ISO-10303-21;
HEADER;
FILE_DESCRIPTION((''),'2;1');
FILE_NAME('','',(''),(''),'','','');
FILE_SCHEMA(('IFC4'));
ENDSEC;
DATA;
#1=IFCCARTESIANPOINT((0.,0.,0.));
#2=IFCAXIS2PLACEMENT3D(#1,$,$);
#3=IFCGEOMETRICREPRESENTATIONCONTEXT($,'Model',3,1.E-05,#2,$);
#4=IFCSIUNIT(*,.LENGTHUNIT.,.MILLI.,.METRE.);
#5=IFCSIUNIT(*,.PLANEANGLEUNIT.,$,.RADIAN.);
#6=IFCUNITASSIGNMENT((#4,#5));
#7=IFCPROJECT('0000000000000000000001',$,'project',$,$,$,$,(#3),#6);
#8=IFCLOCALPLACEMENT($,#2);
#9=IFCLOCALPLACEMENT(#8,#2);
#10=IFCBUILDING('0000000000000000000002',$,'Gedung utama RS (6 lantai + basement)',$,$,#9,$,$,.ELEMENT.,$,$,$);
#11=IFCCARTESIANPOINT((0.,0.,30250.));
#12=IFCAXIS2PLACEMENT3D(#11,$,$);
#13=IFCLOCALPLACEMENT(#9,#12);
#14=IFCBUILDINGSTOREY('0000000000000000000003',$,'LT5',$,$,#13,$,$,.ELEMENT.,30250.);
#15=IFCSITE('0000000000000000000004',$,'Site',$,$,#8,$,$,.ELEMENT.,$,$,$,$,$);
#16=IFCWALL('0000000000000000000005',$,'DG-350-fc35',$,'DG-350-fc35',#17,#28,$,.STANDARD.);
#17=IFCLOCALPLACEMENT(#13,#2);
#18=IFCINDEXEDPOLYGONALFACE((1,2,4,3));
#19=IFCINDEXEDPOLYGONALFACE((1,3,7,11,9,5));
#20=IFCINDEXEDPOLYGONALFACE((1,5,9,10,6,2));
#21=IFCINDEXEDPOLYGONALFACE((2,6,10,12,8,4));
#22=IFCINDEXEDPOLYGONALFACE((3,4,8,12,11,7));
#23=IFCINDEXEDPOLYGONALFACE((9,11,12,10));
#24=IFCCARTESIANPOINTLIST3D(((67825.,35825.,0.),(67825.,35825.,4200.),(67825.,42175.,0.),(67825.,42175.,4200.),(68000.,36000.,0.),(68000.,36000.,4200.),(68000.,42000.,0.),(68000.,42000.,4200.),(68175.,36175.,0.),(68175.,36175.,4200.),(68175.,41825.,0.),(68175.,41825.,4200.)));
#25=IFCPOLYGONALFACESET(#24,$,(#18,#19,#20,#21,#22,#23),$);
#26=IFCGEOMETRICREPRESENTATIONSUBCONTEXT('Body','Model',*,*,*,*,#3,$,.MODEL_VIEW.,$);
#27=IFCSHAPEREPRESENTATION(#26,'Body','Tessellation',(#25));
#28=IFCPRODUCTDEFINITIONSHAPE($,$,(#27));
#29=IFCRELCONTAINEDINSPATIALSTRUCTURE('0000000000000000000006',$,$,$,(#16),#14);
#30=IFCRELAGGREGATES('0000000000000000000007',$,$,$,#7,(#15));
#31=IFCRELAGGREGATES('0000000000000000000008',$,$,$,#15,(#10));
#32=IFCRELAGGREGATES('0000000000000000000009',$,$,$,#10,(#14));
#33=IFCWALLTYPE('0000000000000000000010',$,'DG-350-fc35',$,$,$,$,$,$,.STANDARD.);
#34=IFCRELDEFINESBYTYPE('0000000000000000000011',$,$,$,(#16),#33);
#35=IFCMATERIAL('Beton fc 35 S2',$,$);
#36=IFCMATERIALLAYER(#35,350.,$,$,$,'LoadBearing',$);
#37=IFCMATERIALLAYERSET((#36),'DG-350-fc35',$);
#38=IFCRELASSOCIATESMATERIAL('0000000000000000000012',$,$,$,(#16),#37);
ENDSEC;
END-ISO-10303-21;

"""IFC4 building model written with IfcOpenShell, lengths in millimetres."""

from ifc_helpers import new_model, si_unit, frame, origin, place, context, subcontext, project, spatial, polyline, outline, extrude, material, layer, layer_set, layer_usage, type_object, element, save


model = new_model("IFC4")

# Units and contexts
model_context = context("Model", 3, precision=1e-05, world=origin())
body_context = subcontext(model_context, "Body", "Model", "MODEL_VIEW")
ifc_project = project(units=[si_unit("LENGTHUNIT", "METRE", prefix="MILLI"), si_unit("PLANEANGLEUNIT", "RADIAN")], contexts=[model_context])

# Site, building, storey
site_placement = place(None, origin())
site = spatial("IfcSite", under=ifc_project, at=site_placement, Name="Site", CompositionType="ELEMENT")
building_placement = place(site_placement, origin())
building = spatial("IfcBuilding", under=site, at=building_placement, Name="Gedung utama RS (6 lantai + basement)", CompositionType="ELEMENT")
storey_placement = place(building_placement, frame((0.0, 0.0, 30250.0)))
storey = spatial("IfcBuildingStorey", under=building, at=storey_placement, Name="LT5", CompositionType="ELEMENT", Elevation=30250.0)

# Shared definitions
ifc_material_1 = material(Name="Beton fc 35 S2")
ifc_layer = layer(ifc_material_1, 350.0, Category="LoadBearing")
ifc_layer_set = layer_set([ifc_layer], Name="DG-350-fc35")
ifc_layer_usage = layer_usage(ifc_layer_set, "AXIS2", "NEGATIVE", 175.0)
wall_type = type_object("IfcWallType", Name="DG-350-fc35", PredefinedType="STANDARD")

# Wall
wall_1_placement = place(storey_placement, frame((68000.0, 42000.0, 0.0), z_axis=(0.0, 0.0, 1.0), x_axis=(0.0, -1.0, 0.0)))
element("IfcWall", 1, at=wall_1_placement, inside=storey, type_object=wall_type, material=ifc_layer_usage, Name="DG-350-fc35", ObjectType="DG-350-fc35", PredefinedType="STANDARD", context=body_context, shape_type="SweptSolid", body=[
    extrude(outline(polyline([(-175.0, -175.0), (0.0, 0.0), (175.0, 175.0), (5825.0, 175.0), (6000.0, 0.0), (6175.0, -175.0), (-175.0, -175.0)])), origin(), (0.0, 0.0, 1.0), 4200.0),
])

save(model, "model.ifc")
